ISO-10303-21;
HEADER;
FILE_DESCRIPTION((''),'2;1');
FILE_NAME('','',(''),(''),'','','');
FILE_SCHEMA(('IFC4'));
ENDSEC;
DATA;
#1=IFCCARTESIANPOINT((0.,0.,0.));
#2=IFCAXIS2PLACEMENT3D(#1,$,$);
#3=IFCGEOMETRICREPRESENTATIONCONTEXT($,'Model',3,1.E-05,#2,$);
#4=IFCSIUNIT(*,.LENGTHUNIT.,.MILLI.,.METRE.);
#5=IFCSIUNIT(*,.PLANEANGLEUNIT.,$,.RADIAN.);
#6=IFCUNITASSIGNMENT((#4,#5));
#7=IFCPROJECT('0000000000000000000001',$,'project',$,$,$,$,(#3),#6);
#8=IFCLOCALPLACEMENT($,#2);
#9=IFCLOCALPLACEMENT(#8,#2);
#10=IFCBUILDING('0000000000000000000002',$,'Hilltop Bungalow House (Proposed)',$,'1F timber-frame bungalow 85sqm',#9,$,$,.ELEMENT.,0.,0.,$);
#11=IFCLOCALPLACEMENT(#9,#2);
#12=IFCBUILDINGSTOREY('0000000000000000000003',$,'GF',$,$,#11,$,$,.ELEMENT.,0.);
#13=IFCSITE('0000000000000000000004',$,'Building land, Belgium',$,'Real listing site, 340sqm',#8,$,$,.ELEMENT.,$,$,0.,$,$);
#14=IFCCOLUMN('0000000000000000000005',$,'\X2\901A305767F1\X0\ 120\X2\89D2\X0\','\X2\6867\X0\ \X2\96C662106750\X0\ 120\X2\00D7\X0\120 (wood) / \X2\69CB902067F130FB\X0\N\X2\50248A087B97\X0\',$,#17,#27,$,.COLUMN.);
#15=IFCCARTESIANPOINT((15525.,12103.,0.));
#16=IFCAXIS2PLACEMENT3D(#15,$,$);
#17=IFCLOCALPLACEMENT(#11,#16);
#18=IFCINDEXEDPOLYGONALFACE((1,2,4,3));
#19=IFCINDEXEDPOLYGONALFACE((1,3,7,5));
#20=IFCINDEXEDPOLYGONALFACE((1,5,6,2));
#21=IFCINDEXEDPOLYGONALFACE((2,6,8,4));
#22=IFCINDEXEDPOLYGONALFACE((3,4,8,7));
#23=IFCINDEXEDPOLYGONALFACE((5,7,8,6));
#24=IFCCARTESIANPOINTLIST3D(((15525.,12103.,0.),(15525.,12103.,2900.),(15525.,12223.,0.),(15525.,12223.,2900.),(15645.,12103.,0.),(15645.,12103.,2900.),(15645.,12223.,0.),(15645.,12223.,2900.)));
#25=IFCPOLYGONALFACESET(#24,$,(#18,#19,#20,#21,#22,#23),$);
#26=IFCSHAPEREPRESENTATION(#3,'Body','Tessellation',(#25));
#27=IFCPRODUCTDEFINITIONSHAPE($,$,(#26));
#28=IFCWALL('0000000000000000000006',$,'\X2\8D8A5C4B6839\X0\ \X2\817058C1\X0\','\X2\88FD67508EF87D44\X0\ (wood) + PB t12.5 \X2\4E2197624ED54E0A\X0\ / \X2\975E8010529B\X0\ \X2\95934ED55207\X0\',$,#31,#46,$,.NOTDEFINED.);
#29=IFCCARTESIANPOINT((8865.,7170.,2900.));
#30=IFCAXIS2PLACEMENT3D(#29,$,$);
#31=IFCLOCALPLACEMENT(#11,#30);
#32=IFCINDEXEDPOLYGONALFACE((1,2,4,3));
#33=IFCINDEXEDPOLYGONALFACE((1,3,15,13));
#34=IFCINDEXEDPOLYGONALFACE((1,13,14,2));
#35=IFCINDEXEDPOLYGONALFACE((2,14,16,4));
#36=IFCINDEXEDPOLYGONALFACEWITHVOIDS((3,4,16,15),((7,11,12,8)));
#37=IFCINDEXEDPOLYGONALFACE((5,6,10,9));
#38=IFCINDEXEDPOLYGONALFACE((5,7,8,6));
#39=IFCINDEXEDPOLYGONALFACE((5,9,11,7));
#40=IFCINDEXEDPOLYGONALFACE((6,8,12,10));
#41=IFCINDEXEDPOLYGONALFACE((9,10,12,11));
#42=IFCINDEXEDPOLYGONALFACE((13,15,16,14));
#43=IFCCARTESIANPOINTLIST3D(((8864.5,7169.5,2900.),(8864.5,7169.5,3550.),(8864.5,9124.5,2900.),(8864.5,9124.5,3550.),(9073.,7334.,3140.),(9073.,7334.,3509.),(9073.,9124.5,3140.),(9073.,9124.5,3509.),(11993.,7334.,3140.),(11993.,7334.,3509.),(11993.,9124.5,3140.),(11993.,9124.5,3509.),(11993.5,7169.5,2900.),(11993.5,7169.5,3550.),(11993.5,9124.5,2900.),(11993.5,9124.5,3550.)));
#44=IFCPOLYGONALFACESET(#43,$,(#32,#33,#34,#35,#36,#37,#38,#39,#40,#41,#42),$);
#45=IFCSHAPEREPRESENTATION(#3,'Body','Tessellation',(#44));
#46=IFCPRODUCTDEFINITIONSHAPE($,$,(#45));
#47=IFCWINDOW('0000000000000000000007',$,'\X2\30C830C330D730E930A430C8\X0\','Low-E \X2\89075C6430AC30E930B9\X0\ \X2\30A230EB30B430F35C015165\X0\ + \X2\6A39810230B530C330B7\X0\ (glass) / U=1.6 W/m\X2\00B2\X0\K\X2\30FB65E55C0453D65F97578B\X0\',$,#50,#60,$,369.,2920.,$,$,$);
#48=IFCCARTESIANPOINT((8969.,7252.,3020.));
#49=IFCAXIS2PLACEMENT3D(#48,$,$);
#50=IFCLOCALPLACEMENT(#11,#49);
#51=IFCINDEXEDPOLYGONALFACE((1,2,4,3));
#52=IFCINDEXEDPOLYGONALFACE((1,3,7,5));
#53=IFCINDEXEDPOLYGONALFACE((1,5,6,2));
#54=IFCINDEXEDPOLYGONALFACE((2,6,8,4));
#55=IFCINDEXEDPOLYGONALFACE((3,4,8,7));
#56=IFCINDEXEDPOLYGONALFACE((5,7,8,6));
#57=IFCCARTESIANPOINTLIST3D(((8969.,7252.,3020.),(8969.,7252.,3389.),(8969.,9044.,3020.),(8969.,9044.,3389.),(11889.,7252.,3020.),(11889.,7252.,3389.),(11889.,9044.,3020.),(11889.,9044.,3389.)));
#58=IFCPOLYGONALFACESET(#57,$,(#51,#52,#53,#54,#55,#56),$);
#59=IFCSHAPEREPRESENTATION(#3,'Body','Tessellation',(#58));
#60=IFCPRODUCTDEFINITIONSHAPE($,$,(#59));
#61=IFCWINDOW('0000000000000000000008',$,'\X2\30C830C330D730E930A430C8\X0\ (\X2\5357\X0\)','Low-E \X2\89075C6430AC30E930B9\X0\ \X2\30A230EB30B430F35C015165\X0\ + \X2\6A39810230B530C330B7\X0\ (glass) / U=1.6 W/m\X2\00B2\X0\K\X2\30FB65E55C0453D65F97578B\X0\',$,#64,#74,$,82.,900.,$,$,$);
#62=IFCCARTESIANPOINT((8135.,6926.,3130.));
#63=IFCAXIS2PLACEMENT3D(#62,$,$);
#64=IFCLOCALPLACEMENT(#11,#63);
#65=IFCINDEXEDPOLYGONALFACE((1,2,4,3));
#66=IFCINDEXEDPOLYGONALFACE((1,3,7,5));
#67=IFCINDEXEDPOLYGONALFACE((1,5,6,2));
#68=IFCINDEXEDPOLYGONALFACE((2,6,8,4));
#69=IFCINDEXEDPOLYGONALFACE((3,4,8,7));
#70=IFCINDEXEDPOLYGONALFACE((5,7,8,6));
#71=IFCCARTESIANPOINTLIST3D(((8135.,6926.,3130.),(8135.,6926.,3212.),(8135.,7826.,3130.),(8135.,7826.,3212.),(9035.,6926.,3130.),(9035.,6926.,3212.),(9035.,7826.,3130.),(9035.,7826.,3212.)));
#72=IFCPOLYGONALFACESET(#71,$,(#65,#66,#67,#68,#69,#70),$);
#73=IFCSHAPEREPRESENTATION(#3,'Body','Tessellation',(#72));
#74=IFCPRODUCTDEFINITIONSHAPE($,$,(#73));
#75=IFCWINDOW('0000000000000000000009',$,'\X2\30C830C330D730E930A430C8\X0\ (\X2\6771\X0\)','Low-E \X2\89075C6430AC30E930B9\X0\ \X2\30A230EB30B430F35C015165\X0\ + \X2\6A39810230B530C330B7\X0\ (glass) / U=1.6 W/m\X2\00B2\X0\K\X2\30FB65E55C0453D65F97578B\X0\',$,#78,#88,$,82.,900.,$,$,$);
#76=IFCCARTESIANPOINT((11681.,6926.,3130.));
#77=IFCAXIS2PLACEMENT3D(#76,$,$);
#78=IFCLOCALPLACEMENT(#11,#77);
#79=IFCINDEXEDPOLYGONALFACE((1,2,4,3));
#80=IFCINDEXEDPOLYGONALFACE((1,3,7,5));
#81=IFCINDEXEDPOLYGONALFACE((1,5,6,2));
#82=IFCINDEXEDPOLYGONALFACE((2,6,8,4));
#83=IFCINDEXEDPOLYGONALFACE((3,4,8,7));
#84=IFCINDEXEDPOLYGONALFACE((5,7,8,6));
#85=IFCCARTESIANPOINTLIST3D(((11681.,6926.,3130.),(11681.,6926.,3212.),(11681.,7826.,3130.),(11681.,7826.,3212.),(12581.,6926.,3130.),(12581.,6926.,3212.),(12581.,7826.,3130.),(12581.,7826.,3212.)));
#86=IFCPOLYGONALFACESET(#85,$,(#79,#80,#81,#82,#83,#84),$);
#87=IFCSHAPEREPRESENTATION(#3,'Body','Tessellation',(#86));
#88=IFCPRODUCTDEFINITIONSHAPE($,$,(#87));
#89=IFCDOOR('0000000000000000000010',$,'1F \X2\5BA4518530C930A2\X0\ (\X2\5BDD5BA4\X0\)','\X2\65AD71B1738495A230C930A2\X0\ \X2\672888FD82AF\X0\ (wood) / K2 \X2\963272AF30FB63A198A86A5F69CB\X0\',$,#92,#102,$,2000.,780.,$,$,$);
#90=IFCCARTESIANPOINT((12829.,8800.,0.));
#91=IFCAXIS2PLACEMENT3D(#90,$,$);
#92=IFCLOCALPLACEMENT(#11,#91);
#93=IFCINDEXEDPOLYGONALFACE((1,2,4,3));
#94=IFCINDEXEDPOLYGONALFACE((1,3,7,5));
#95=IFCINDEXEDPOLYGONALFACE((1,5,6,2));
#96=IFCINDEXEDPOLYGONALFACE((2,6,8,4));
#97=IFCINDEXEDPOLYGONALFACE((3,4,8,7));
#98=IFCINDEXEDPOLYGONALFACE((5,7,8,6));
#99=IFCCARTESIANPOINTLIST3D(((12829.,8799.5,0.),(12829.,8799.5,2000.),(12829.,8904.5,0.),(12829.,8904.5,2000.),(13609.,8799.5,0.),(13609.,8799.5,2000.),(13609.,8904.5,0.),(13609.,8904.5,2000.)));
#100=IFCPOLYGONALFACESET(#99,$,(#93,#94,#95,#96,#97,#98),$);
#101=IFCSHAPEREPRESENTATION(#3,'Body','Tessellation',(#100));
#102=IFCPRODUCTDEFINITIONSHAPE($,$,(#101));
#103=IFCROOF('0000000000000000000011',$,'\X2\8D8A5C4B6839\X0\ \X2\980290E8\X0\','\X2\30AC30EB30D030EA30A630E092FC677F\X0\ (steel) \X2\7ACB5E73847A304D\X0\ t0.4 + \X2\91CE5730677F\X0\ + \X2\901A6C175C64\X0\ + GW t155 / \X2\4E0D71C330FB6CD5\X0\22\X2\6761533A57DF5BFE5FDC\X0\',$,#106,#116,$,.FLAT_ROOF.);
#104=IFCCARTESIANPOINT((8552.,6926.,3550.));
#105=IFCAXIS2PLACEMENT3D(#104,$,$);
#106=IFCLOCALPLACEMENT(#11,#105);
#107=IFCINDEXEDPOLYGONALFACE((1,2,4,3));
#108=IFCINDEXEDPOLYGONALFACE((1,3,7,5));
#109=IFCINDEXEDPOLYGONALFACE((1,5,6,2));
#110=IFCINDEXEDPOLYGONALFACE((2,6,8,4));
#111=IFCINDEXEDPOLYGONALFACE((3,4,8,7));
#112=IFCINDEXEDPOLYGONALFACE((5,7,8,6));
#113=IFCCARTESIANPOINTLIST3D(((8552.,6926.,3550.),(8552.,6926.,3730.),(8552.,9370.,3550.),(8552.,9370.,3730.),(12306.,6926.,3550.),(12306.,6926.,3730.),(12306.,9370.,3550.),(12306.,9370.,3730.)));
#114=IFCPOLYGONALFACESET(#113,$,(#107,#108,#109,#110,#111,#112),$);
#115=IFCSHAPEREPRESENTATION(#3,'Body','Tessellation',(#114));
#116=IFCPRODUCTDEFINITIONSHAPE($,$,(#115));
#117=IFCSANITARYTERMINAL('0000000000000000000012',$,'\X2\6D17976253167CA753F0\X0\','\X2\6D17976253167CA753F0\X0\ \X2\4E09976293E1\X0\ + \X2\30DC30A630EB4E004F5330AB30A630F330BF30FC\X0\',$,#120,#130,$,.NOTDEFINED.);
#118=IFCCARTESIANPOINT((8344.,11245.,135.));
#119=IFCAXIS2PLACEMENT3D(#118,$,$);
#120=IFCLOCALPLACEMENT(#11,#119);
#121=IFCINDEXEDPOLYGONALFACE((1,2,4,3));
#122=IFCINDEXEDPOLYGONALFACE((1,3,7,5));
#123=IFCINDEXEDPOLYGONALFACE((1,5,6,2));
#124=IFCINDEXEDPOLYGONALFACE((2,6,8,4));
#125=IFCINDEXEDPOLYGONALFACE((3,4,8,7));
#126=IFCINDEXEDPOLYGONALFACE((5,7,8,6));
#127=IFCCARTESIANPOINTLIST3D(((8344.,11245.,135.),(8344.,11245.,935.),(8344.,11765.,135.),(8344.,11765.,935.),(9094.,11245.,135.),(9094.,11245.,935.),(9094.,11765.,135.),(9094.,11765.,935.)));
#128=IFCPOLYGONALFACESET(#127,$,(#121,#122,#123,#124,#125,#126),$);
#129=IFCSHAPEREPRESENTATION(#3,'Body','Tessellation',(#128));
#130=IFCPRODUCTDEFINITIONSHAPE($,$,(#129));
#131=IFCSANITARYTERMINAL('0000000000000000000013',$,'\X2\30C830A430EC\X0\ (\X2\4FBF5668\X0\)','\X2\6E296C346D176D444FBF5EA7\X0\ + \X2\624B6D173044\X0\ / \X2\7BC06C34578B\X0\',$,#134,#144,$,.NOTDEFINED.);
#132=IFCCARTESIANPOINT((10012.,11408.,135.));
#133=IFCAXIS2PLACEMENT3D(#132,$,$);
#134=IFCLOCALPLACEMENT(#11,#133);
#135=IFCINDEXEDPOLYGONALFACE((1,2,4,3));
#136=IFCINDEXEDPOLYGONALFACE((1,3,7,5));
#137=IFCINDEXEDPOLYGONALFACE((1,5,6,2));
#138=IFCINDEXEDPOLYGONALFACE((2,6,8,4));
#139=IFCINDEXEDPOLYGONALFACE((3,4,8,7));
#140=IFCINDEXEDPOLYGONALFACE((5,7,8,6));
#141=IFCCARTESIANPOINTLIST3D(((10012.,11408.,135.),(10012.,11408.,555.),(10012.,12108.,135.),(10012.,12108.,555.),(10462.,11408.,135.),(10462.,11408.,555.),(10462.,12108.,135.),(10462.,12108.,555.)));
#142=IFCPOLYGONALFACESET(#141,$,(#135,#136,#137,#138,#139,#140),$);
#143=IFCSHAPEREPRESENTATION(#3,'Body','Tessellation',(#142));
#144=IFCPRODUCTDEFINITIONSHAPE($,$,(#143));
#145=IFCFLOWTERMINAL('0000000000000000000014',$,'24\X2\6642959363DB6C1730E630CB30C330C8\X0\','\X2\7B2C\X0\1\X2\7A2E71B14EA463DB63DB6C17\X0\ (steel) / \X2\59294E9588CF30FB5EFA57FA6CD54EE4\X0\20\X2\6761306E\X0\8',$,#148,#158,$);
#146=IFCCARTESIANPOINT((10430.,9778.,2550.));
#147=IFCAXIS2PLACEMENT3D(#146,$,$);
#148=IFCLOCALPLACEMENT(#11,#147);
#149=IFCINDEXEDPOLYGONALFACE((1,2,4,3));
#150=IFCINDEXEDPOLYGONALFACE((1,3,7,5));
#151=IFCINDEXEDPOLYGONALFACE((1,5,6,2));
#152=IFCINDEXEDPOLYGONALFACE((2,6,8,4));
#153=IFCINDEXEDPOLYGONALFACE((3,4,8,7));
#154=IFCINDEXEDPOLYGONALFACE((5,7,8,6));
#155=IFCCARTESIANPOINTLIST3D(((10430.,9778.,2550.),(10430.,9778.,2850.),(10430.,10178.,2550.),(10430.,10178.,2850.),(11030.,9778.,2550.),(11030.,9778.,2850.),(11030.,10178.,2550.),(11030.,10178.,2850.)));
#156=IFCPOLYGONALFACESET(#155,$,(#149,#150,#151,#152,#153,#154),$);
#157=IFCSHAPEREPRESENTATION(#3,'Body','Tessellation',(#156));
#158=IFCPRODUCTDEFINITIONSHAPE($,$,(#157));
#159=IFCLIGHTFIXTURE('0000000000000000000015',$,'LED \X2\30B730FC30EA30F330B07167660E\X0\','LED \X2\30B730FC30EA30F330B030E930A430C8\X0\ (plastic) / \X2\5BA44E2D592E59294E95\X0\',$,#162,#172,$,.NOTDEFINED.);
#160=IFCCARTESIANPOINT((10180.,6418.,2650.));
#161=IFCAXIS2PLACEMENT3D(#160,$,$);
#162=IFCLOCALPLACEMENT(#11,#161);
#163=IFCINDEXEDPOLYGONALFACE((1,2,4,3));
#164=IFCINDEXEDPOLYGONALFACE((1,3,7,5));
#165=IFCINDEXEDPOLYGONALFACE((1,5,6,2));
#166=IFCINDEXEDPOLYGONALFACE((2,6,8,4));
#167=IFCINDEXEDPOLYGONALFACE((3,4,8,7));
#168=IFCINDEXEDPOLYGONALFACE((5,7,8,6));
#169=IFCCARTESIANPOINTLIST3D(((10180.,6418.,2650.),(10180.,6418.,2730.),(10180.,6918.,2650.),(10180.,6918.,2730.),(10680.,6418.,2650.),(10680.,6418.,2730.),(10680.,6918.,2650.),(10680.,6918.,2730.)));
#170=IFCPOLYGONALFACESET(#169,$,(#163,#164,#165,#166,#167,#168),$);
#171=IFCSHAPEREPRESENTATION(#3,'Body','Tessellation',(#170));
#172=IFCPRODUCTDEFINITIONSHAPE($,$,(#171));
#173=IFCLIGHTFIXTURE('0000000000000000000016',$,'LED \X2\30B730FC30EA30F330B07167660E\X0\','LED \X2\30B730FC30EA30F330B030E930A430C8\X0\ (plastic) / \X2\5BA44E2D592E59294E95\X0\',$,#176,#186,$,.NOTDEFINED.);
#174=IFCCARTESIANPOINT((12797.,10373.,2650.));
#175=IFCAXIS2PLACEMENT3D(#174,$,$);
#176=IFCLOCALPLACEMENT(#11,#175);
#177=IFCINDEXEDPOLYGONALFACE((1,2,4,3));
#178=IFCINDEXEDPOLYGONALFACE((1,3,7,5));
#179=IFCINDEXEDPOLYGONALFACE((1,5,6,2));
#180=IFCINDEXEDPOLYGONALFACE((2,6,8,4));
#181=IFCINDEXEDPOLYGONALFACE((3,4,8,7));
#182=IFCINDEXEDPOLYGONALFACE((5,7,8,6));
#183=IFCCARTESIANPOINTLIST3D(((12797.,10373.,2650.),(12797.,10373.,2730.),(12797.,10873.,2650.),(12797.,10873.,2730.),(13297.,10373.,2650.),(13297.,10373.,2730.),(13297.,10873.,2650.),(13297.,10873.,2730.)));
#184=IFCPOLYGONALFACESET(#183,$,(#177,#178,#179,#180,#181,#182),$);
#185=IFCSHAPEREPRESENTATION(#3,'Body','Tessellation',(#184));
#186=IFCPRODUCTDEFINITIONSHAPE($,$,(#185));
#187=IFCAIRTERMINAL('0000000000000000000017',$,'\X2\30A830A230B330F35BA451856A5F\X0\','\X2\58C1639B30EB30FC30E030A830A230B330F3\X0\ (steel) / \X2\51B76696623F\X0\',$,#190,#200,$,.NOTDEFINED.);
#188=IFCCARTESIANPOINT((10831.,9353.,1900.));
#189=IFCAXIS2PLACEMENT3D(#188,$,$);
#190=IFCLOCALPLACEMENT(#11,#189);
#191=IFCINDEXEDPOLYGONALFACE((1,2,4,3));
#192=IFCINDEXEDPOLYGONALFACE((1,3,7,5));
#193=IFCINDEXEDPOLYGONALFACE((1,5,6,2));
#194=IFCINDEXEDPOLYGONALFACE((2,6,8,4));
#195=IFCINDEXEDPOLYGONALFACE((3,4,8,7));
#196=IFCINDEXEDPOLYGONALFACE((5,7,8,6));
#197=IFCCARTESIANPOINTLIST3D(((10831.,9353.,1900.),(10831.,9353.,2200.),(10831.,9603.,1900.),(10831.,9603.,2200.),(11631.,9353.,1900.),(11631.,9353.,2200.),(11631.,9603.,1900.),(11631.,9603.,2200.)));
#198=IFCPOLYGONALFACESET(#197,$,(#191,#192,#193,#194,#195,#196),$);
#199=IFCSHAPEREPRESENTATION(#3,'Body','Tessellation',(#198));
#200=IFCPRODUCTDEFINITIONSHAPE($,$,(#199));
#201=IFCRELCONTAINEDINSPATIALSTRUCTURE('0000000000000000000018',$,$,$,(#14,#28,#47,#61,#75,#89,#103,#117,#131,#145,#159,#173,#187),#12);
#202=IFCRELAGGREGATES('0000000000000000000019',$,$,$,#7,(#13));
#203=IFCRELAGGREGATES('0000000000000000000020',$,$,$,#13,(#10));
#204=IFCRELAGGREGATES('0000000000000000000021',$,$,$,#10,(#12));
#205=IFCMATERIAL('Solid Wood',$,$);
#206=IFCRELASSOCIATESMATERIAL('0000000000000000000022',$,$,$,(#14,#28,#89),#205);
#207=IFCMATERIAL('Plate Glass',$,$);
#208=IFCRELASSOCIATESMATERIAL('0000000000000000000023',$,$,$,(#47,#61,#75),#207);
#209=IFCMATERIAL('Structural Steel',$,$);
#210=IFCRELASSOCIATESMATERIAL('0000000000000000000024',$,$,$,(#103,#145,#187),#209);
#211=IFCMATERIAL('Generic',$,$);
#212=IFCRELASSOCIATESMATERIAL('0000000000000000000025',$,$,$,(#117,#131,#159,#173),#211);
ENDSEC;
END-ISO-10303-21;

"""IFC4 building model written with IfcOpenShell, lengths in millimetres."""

from ifc_helpers import new_model, si_unit, frame, frame_2d, origin, place, context, project, spatial, rectangle, extrude, material, element, fill, save


model = new_model("IFC4")

# Units and contexts
model_context = context("Model", 3, precision=1e-05, world=origin())
ifc_project = project(units=[si_unit("LENGTHUNIT", "METRE", prefix="MILLI"), si_unit("PLANEANGLEUNIT", "RADIAN")], contexts=[model_context])

# Site, building, storey
site_placement = place(None, origin())
site = spatial("IfcSite", under=ifc_project, at=site_placement, Name="Building land, Belgium", ObjectType="Real listing site, 340sqm", CompositionType="ELEMENT", RefElevation=0.0)
building_placement = place(site_placement, origin())
building = spatial("IfcBuilding", under=site, at=building_placement, Name="Hilltop Bungalow House (Proposed)", ObjectType="1F timber-frame bungalow 85sqm", CompositionType="ELEMENT", ElevationOfRefHeight=0.0, ElevationOfTerrain=0.0)
storey_placement = place(building_placement, origin())
storey = spatial("IfcBuildingStorey", under=building, at=storey_placement, Name="GF", CompositionType="ELEMENT", Elevation=0.0)

# Column
ifc_material_1 = material(Name="Solid Wood")
column_1_placement = place(storey_placement, frame((15525.0, 12103.0, 0.0)))
element("IfcColumn", 1, at=column_1_placement, inside=storey, material=ifc_material_1, Name="通し柱 120角", Description="桧 集成材 120×120 (wood) / 構造柱・N値計算", PredefinedType="COLUMN", context=model_context, shape_type="SweptSolid", body=[
    extrude(rectangle(XDim=120.0, YDim=120.0, at=frame_2d((60.0, 60.0))), frame((15525.0, 12103.0, 0.0)), (0.0, 0.0, 1.0), 2900.0),
])

# Wall, openings, windows
wall_1_placement = place(storey_placement, frame((8865.0, 7170.0, 2900.0)))
wall_1 = element("IfcWall", 2, at=wall_1_placement, inside=storey, material=ifc_material_1, Name="越屋根 腰壁", Description="製材軸組 (wood) + PB t12.5 両面仕上 / 非耐力 間仕切", PredefinedType="NOTDEFINED", context=model_context, shape_type="SweptSolid", body=[
    extrude(rectangle(XDim=3129.0, YDim=1955.0, at=frame_2d((1564.0, 977.0))), frame((8865.0, 7170.0, 2900.0)), (0.0, 0.0, 1.0), 650.0),
])
opening_1_placement = place(storey_placement, frame((8969.0, 7252.0, 3020.0)))
opening_1 = element("IfcOpeningElement", 3, at=opening_1_placement, cuts=wall_1, PredefinedType="NOTDEFINED", context=model_context, shape_type="SweptSolid", body=[
    extrude(rectangle(XDim=2920.0, YDim=1792.0, at=frame_2d((1460.0, 896.0))), frame((8969.0, 7252.0, 3020.0)), (0.0, 0.0, 1.0), 369.0),
])
opening_2_placement = place(storey_placement, frame((8135.0, 6926.0, 3130.0)))
opening_2 = element("IfcOpeningElement", 4, at=opening_2_placement, cuts=wall_1, PredefinedType="NOTDEFINED", context=model_context, shape_type="SweptSolid", body=[
    extrude(rectangle(XDim=900.0, YDim=900.0, at=frame_2d((450.0, 450.0))), frame((8135.0, 6926.0, 3130.0)), (0.0, 0.0, 1.0), 82.0),
])
opening_3_placement = place(storey_placement, frame((11681.0, 6926.0, 3130.0)))
opening_3 = element("IfcOpeningElement", 5, at=opening_3_placement, cuts=wall_1, PredefinedType="NOTDEFINED", context=model_context, shape_type="SweptSolid", body=[
    extrude(rectangle(XDim=900.0, YDim=900.0, at=frame_2d((450.0, 450.0))), frame((11681.0, 6926.0, 3130.0)), (0.0, 0.0, 1.0), 82.0),
])
ifc_material_2 = material(Name="Plate Glass")
window_1_placement = place(storey_placement, frame((8969.0, 7252.0, 3020.0)))
window_1 = element("IfcWindow", 6, at=window_1_placement, inside=storey, material=ifc_material_2, Name="トップライト", Description="Low-E 複層ガラス アルゴン封入 + 樹脂サッシ (glass) / U=1.6 W/m²K・日射取得型", OverallHeight=369.0, OverallWidth=2920.0, context=model_context, shape_type="SweptSolid", body=[
    extrude(rectangle(XDim=2920.0, YDim=1792.0, at=frame_2d((1460.0, 896.0))), frame((8969.0, 7252.0, 3020.0)), (0.0, 0.0, 1.0), 369.0),
])
fill(opening_1, window_1)
window_2_placement = place(storey_placement, frame((8135.0, 6926.0, 3130.0)))
window_2 = element("IfcWindow", 7, at=window_2_placement, inside=storey, material=ifc_material_2, Name="トップライト (南)", Description="Low-E 複層ガラス アルゴン封入 + 樹脂サッシ (glass) / U=1.6 W/m²K・日射取得型", OverallHeight=82.0, OverallWidth=900.0, context=model_context, shape_type="SweptSolid", body=[
    extrude(rectangle(XDim=900.0, YDim=900.0, at=frame_2d((450.0, 450.0))), frame((8135.0, 6926.0, 3130.0)), (0.0, 0.0, 1.0), 82.0),
])
fill(opening_2, window_2)
window_3_placement = place(storey_placement, frame((11681.0, 6926.0, 3130.0)))
window_3 = element("IfcWindow", 8, at=window_3_placement, inside=storey, material=ifc_material_2, Name="トップライト (東)", Description="Low-E 複層ガラス アルゴン封入 + 樹脂サッシ (glass) / U=1.6 W/m²K・日射取得型", OverallHeight=82.0, OverallWidth=900.0, context=model_context, shape_type="SweptSolid", body=[
    extrude(rectangle(XDim=900.0, YDim=900.0, at=frame_2d((450.0, 450.0))), frame((11681.0, 6926.0, 3130.0)), (0.0, 0.0, 1.0), 82.0),
])
fill(opening_3, window_3)

# Door
door_placement = place(storey_placement, frame((12829.0, 8800.0, 0.0)))
element("IfcDoor", 9, at=door_placement, inside=storey, material=ifc_material_1, Name="1F 室内ドア (寝室)", Description="断熱玄関ドア 木製芯 (wood) / K2 防犯・採風機構", OverallHeight=2000.0, OverallWidth=780.0, context=model_context, shape_type="SweptSolid", body=[
    extrude(rectangle(XDim=780.0, YDim=105.0, at=frame_2d((390.0, 52.0))), frame((12829.0, 8800.0, 0.0)), (0.0, 0.0, 1.0), 2000.0),
])

# Roof
ifc_material_3 = material(Name="Structural Steel")
roof_placement = place(storey_placement, frame((8552.0, 6926.0, 3550.0)))
element("IfcRoof", 10, at=roof_placement, inside=storey, material=ifc_material_3, Name="越屋根 頂部", Description="ガルバリウム鋼板 (steel) 立平葺き t0.4 + 野地板 + 通気層 + GW t155 / 不燃・法22条区域対応", PredefinedType="FLAT_ROOF", context=model_context, shape_type="SweptSolid", body=[
    extrude(rectangle(XDim=3754.0, YDim=2444.0, at=frame_2d((1877.0, 1222.0))), frame((8552.0, 6926.0, 3550.0)), (0.0, 0.0, 1.0), 180.0),
])

# Sanitary terminals
ifc_material_4 = material(Name="Generic")
sanitary_terminal_1_placement = place(storey_placement, frame((8344.0, 11245.0, 135.0)))
element("IfcSanitaryTerminal", 11, at=sanitary_terminal_1_placement, inside=storey, material=ifc_material_4, Name="洗面化粧台", Description="洗面化粧台 三面鏡 + ボウル一体カウンター", PredefinedType="NOTDEFINED", context=model_context, shape_type="SweptSolid", body=[
    extrude(rectangle(XDim=750.0, YDim=520.0, at=frame_2d((375.0, 260.0))), frame((8344.0, 11245.0, 135.0)), (0.0, 0.0, 1.0), 800.0),
])
sanitary_terminal_2_placement = place(storey_placement, frame((10012.0, 11408.0, 135.0)))
element("IfcSanitaryTerminal", 12, at=sanitary_terminal_2_placement, inside=storey, material=ifc_material_4, Name="トイレ (便器)", Description="温水洗浄便座 + 手洗い / 節水型", PredefinedType="NOTDEFINED", context=model_context, shape_type="SweptSolid", body=[
    extrude(rectangle(XDim=450.0, YDim=700.0, at=frame_2d((225.0, 350.0))), frame((10012.0, 11408.0, 135.0)), (0.0, 0.0, 1.0), 420.0),
])

# Flow terminal
flow_terminal_placement = place(storey_placement, frame((10430.0, 9778.0, 2550.0)))
element("IfcFlowTerminal", 13, at=flow_terminal_placement, inside=storey, material=ifc_material_3, Name="24時間換気ユニット", Description="第1種熱交換換気 (steel) / 天井裏・建基法令20条の8", context=model_context, shape_type="SweptSolid", body=[
    extrude(rectangle(XDim=600.0, YDim=400.0, at=frame_2d((300.0, 200.0))), frame((10430.0, 9778.0, 2550.0)), (0.0, 0.0, 1.0), 300.0),
])

# Light fixtures
light_fixture_1_placement = place(storey_placement, frame((10180.0, 6418.0, 2650.0)))
element("IfcLightFixture", 14, at=light_fixture_1_placement, inside=storey, material=ifc_material_4, Name="LED シーリング照明", Description="LED シーリングライト (plastic) / 室中央天井", PredefinedType="NOTDEFINED", context=model_context, shape_type="SweptSolid", body=[
    extrude(rectangle(XDim=500.0, YDim=500.0, at=frame_2d((250.0, 250.0))), frame((10180.0, 6418.0, 2650.0)), (0.0, 0.0, 1.0), 80.0),
])
light_fixture_2_placement = place(storey_placement, frame((12797.0, 10373.0, 2650.0)))
element("IfcLightFixture", 15, at=light_fixture_2_placement, inside=storey, material=ifc_material_4, Name="LED シーリング照明", Description="LED シーリングライト (plastic) / 室中央天井", PredefinedType="NOTDEFINED", context=model_context, shape_type="SweptSolid", body=[
    extrude(rectangle(XDim=500.0, YDim=500.0, at=frame_2d((250.0, 250.0))), frame((12797.0, 10373.0, 2650.0)), (0.0, 0.0, 1.0), 80.0),
])

# Air terminal
air_terminal_placement = place(storey_placement, frame((10831.0, 9353.0, 1900.0)))
element("IfcAirTerminal", 16, at=air_terminal_placement, inside=storey, material=ifc_material_3, Name="エアコン室内機", Description="壁掛ルームエアコン (steel) / 冷暖房", PredefinedType="NOTDEFINED", context=model_context, shape_type="SweptSolid", body=[
    extrude(rectangle(XDim=800.0, YDim=250.0, at=frame_2d((400.0, 125.0))), frame((10831.0, 9353.0, 1900.0)), (0.0, 0.0, 1.0), 300.0),
])

save(model, "model.ifc")
